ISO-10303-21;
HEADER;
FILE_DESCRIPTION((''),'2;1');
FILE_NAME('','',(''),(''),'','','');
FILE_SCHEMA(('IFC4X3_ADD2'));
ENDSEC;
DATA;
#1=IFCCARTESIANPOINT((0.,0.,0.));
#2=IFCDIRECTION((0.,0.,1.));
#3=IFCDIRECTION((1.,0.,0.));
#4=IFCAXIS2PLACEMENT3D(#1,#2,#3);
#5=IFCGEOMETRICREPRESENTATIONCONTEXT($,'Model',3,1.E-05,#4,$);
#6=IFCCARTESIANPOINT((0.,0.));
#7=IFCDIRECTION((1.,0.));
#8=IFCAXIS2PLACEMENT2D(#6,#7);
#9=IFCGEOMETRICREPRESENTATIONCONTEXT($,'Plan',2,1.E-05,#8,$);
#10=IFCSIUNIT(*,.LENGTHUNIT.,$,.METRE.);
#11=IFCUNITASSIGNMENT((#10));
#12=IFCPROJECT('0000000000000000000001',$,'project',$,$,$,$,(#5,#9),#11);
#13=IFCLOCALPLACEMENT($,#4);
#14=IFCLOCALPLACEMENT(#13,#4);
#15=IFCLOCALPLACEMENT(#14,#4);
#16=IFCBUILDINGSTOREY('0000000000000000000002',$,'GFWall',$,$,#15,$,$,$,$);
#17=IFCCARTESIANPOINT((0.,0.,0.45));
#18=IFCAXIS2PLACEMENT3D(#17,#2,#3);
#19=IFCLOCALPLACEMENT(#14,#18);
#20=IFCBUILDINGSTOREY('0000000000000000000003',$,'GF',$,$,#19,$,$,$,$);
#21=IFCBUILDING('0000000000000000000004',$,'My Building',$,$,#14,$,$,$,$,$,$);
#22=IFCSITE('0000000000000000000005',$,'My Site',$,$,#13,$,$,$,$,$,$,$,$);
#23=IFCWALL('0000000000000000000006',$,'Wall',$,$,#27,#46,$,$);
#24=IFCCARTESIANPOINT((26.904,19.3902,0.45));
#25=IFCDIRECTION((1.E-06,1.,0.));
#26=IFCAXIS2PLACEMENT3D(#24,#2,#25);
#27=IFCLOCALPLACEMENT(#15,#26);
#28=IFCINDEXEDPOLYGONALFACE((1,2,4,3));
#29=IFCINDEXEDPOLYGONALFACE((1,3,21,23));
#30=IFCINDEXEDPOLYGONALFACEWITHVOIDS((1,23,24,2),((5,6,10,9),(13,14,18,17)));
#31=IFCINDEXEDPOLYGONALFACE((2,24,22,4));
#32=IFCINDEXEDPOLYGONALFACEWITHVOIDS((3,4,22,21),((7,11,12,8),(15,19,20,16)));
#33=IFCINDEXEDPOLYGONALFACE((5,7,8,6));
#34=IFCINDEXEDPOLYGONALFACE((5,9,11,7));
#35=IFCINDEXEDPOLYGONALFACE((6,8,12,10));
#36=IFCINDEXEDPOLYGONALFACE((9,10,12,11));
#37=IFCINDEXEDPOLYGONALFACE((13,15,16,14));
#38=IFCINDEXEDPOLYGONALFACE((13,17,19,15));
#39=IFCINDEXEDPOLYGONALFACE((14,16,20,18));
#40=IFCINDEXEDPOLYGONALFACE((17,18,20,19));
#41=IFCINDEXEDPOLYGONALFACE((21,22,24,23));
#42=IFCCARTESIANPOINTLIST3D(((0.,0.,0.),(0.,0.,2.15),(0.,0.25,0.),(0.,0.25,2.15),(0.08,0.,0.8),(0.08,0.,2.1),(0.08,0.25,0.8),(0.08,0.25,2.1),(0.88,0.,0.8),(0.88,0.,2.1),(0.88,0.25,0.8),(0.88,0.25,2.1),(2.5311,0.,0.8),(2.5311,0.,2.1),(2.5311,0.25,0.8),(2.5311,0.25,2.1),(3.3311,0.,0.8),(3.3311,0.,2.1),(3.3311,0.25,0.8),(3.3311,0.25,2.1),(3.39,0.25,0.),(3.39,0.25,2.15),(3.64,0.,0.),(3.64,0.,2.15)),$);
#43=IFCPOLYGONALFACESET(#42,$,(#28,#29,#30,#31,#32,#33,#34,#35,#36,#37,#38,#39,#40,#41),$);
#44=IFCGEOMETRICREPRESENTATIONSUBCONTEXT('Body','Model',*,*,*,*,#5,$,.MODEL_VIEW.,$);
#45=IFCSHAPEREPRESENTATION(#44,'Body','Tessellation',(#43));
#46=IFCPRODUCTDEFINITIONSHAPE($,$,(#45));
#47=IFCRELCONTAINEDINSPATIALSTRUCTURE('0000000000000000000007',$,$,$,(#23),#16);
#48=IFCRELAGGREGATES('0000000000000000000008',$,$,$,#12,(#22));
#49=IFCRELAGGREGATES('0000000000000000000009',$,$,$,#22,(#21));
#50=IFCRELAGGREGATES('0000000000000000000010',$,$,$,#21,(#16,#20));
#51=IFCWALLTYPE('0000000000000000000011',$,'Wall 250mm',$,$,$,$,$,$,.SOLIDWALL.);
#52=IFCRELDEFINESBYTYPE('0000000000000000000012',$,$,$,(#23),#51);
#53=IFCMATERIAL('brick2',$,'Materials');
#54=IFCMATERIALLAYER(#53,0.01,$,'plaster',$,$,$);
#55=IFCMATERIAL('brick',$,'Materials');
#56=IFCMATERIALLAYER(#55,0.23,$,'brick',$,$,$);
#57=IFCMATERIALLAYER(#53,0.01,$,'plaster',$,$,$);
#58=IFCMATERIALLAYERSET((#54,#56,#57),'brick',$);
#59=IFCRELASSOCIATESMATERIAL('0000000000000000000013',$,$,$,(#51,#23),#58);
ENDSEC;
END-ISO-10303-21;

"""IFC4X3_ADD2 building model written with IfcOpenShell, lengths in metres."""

from ifc_helpers import new_model, si_unit, frame, origin_with_axes, origin_2d_with_axis, place, context, subcontext, project, spatial, line, indexed_curve, outline, extrude, source, transform, mapped, material, layer, layer_set, layer_usage, type_object, element, save


model = new_model("IFC4X3_ADD2")

# Units and contexts
model_context = context("Model", 3, precision=1e-05, world=origin_with_axes())
plan_context = context("Plan", 2, precision=1e-05, world=origin_2d_with_axis())
body_context_1 = subcontext(model_context, "Body", "Model", "MODEL_VIEW")
ifc_project = project(units=[si_unit("LENGTHUNIT", "METRE")], contexts=[model_context, plan_context])

# Site, building, storey
site_placement = place(None, origin_with_axes())
site = spatial("IfcSite", under=ifc_project, at=site_placement, Name="My Site")
building_placement = place(site_placement, origin_with_axes())
building = spatial("IfcBuilding", under=site, at=building_placement, Name="My Building")
storey_1_placement = place(building_placement, origin_with_axes())
storey_1 = spatial("IfcBuildingStorey", under=building, at=storey_1_placement, Name="GFWall")

# Shared definitions
ifc_material_1 = material(Name="brick2", Category="Materials")
ifc_layer_1 = layer(ifc_material_1, 0.01, Name="plaster")
ifc_material_2 = material(Name="brick", Category="Materials")
ifc_layer_2 = layer(ifc_material_2, 0.23, Name="brick")
ifc_layer_3 = layer(ifc_material_1, 0.01, Name="plaster")
ifc_layer_set_1 = layer_set([ifc_layer_1, ifc_layer_2, ifc_layer_3], Name="brick")
wall_type_1 = type_object("IfcWallType", Name="Wall 250mm", PredefinedType="SOLIDWALL", material=ifc_layer_set_1)

# Shared definitions
storey_2_placement = place(building_placement, frame((0.0, 0.0, 0.45), z_axis=(0.0, 0.0, 1.0), x_axis=(1.0, 0.0, 0.0)))
storey_2 = spatial("IfcBuildingStorey", under=building, at=storey_2_placement, Name="GF")

# Wall, openings
ifc_layer_usage_1 = layer_usage(ifc_layer_set_1, "AXIS2", "POSITIVE", 0.0)
wall_1_placement = place(storey_1_placement, frame((26.904, 19.3902, 0.45), z_axis=(0.0, 0.0, 1.0), x_axis=(0.000001, 1.0, 0.0)))
wall_1 = element("IfcWall", 1, at=wall_1_placement, inside=storey_1, type_object=wall_type_1, material=ifc_layer_usage_1, Name="Wall", context=body_context_1, shape_type="SweptSolid", body=[
    extrude(outline(indexed_curve([(0.0, 0.0), (0.0, 0.25), (3.39, 0.25), (3.64, 0.0)], segments=[line(1, 2, 3, 4, 1)])), origin_with_axes(), (0.0, 0.0, 1.0), 2.15),
])
shared_shape_1 = source(origin_with_axes(), body_context_1, "Body", "SweptSolid", [
    extrude(outline(indexed_curve([(0.0, 0.0), (0.8, 0.0), (0.8, 1.3), (0.0, 1.3)], segments=[line(1, 2, 3, 4, 1)])), frame((-0.4, -0.6, 0.0), z_axis=(0.0, -1.0, 0.0), x_axis=(1.0, 0.0, 0.0)), (0.0, 0.0, -1.0), 1.2),
])
opening_1_placement = place(wall_1_placement, frame((0.48, 0.16, 0.8), z_axis=(0.0, 0.0, 1.0), x_axis=(1.0, 0.0, 0.0)))
element("IfcOpeningElement", 2, at=opening_1_placement, cuts=wall_1, PredefinedType="OPENING", context=body_context_1, shape_type="MappedRepresentation", body=[
    mapped(shared_shape_1, transform((0.0, 0.0, 0.0), x_axis=(1.0, 0.0, 0.0), y_axis=(0.0, 1.0, 0.0), z_axis=(0.0, 0.0, 1.0), scale=1.0)),
])
opening_2_placement = place(wall_1_placement, frame((2.9311, 0.16, 0.8), z_axis=(0.0, 0.0, 1.0), x_axis=(1.0, 0.0, 0.0)))
element("IfcOpeningElement", 3, at=opening_2_placement, cuts=wall_1, PredefinedType="OPENING", context=body_context_1, shape_type="MappedRepresentation", body=[
    mapped(shared_shape_1, transform((0.0, 0.0, 0.0), x_axis=(1.0, 0.0, 0.0), y_axis=(0.0, 1.0, 0.0), z_axis=(0.0, 0.0, 1.0), scale=1.0)),
])

save(model, "model.ifc")
